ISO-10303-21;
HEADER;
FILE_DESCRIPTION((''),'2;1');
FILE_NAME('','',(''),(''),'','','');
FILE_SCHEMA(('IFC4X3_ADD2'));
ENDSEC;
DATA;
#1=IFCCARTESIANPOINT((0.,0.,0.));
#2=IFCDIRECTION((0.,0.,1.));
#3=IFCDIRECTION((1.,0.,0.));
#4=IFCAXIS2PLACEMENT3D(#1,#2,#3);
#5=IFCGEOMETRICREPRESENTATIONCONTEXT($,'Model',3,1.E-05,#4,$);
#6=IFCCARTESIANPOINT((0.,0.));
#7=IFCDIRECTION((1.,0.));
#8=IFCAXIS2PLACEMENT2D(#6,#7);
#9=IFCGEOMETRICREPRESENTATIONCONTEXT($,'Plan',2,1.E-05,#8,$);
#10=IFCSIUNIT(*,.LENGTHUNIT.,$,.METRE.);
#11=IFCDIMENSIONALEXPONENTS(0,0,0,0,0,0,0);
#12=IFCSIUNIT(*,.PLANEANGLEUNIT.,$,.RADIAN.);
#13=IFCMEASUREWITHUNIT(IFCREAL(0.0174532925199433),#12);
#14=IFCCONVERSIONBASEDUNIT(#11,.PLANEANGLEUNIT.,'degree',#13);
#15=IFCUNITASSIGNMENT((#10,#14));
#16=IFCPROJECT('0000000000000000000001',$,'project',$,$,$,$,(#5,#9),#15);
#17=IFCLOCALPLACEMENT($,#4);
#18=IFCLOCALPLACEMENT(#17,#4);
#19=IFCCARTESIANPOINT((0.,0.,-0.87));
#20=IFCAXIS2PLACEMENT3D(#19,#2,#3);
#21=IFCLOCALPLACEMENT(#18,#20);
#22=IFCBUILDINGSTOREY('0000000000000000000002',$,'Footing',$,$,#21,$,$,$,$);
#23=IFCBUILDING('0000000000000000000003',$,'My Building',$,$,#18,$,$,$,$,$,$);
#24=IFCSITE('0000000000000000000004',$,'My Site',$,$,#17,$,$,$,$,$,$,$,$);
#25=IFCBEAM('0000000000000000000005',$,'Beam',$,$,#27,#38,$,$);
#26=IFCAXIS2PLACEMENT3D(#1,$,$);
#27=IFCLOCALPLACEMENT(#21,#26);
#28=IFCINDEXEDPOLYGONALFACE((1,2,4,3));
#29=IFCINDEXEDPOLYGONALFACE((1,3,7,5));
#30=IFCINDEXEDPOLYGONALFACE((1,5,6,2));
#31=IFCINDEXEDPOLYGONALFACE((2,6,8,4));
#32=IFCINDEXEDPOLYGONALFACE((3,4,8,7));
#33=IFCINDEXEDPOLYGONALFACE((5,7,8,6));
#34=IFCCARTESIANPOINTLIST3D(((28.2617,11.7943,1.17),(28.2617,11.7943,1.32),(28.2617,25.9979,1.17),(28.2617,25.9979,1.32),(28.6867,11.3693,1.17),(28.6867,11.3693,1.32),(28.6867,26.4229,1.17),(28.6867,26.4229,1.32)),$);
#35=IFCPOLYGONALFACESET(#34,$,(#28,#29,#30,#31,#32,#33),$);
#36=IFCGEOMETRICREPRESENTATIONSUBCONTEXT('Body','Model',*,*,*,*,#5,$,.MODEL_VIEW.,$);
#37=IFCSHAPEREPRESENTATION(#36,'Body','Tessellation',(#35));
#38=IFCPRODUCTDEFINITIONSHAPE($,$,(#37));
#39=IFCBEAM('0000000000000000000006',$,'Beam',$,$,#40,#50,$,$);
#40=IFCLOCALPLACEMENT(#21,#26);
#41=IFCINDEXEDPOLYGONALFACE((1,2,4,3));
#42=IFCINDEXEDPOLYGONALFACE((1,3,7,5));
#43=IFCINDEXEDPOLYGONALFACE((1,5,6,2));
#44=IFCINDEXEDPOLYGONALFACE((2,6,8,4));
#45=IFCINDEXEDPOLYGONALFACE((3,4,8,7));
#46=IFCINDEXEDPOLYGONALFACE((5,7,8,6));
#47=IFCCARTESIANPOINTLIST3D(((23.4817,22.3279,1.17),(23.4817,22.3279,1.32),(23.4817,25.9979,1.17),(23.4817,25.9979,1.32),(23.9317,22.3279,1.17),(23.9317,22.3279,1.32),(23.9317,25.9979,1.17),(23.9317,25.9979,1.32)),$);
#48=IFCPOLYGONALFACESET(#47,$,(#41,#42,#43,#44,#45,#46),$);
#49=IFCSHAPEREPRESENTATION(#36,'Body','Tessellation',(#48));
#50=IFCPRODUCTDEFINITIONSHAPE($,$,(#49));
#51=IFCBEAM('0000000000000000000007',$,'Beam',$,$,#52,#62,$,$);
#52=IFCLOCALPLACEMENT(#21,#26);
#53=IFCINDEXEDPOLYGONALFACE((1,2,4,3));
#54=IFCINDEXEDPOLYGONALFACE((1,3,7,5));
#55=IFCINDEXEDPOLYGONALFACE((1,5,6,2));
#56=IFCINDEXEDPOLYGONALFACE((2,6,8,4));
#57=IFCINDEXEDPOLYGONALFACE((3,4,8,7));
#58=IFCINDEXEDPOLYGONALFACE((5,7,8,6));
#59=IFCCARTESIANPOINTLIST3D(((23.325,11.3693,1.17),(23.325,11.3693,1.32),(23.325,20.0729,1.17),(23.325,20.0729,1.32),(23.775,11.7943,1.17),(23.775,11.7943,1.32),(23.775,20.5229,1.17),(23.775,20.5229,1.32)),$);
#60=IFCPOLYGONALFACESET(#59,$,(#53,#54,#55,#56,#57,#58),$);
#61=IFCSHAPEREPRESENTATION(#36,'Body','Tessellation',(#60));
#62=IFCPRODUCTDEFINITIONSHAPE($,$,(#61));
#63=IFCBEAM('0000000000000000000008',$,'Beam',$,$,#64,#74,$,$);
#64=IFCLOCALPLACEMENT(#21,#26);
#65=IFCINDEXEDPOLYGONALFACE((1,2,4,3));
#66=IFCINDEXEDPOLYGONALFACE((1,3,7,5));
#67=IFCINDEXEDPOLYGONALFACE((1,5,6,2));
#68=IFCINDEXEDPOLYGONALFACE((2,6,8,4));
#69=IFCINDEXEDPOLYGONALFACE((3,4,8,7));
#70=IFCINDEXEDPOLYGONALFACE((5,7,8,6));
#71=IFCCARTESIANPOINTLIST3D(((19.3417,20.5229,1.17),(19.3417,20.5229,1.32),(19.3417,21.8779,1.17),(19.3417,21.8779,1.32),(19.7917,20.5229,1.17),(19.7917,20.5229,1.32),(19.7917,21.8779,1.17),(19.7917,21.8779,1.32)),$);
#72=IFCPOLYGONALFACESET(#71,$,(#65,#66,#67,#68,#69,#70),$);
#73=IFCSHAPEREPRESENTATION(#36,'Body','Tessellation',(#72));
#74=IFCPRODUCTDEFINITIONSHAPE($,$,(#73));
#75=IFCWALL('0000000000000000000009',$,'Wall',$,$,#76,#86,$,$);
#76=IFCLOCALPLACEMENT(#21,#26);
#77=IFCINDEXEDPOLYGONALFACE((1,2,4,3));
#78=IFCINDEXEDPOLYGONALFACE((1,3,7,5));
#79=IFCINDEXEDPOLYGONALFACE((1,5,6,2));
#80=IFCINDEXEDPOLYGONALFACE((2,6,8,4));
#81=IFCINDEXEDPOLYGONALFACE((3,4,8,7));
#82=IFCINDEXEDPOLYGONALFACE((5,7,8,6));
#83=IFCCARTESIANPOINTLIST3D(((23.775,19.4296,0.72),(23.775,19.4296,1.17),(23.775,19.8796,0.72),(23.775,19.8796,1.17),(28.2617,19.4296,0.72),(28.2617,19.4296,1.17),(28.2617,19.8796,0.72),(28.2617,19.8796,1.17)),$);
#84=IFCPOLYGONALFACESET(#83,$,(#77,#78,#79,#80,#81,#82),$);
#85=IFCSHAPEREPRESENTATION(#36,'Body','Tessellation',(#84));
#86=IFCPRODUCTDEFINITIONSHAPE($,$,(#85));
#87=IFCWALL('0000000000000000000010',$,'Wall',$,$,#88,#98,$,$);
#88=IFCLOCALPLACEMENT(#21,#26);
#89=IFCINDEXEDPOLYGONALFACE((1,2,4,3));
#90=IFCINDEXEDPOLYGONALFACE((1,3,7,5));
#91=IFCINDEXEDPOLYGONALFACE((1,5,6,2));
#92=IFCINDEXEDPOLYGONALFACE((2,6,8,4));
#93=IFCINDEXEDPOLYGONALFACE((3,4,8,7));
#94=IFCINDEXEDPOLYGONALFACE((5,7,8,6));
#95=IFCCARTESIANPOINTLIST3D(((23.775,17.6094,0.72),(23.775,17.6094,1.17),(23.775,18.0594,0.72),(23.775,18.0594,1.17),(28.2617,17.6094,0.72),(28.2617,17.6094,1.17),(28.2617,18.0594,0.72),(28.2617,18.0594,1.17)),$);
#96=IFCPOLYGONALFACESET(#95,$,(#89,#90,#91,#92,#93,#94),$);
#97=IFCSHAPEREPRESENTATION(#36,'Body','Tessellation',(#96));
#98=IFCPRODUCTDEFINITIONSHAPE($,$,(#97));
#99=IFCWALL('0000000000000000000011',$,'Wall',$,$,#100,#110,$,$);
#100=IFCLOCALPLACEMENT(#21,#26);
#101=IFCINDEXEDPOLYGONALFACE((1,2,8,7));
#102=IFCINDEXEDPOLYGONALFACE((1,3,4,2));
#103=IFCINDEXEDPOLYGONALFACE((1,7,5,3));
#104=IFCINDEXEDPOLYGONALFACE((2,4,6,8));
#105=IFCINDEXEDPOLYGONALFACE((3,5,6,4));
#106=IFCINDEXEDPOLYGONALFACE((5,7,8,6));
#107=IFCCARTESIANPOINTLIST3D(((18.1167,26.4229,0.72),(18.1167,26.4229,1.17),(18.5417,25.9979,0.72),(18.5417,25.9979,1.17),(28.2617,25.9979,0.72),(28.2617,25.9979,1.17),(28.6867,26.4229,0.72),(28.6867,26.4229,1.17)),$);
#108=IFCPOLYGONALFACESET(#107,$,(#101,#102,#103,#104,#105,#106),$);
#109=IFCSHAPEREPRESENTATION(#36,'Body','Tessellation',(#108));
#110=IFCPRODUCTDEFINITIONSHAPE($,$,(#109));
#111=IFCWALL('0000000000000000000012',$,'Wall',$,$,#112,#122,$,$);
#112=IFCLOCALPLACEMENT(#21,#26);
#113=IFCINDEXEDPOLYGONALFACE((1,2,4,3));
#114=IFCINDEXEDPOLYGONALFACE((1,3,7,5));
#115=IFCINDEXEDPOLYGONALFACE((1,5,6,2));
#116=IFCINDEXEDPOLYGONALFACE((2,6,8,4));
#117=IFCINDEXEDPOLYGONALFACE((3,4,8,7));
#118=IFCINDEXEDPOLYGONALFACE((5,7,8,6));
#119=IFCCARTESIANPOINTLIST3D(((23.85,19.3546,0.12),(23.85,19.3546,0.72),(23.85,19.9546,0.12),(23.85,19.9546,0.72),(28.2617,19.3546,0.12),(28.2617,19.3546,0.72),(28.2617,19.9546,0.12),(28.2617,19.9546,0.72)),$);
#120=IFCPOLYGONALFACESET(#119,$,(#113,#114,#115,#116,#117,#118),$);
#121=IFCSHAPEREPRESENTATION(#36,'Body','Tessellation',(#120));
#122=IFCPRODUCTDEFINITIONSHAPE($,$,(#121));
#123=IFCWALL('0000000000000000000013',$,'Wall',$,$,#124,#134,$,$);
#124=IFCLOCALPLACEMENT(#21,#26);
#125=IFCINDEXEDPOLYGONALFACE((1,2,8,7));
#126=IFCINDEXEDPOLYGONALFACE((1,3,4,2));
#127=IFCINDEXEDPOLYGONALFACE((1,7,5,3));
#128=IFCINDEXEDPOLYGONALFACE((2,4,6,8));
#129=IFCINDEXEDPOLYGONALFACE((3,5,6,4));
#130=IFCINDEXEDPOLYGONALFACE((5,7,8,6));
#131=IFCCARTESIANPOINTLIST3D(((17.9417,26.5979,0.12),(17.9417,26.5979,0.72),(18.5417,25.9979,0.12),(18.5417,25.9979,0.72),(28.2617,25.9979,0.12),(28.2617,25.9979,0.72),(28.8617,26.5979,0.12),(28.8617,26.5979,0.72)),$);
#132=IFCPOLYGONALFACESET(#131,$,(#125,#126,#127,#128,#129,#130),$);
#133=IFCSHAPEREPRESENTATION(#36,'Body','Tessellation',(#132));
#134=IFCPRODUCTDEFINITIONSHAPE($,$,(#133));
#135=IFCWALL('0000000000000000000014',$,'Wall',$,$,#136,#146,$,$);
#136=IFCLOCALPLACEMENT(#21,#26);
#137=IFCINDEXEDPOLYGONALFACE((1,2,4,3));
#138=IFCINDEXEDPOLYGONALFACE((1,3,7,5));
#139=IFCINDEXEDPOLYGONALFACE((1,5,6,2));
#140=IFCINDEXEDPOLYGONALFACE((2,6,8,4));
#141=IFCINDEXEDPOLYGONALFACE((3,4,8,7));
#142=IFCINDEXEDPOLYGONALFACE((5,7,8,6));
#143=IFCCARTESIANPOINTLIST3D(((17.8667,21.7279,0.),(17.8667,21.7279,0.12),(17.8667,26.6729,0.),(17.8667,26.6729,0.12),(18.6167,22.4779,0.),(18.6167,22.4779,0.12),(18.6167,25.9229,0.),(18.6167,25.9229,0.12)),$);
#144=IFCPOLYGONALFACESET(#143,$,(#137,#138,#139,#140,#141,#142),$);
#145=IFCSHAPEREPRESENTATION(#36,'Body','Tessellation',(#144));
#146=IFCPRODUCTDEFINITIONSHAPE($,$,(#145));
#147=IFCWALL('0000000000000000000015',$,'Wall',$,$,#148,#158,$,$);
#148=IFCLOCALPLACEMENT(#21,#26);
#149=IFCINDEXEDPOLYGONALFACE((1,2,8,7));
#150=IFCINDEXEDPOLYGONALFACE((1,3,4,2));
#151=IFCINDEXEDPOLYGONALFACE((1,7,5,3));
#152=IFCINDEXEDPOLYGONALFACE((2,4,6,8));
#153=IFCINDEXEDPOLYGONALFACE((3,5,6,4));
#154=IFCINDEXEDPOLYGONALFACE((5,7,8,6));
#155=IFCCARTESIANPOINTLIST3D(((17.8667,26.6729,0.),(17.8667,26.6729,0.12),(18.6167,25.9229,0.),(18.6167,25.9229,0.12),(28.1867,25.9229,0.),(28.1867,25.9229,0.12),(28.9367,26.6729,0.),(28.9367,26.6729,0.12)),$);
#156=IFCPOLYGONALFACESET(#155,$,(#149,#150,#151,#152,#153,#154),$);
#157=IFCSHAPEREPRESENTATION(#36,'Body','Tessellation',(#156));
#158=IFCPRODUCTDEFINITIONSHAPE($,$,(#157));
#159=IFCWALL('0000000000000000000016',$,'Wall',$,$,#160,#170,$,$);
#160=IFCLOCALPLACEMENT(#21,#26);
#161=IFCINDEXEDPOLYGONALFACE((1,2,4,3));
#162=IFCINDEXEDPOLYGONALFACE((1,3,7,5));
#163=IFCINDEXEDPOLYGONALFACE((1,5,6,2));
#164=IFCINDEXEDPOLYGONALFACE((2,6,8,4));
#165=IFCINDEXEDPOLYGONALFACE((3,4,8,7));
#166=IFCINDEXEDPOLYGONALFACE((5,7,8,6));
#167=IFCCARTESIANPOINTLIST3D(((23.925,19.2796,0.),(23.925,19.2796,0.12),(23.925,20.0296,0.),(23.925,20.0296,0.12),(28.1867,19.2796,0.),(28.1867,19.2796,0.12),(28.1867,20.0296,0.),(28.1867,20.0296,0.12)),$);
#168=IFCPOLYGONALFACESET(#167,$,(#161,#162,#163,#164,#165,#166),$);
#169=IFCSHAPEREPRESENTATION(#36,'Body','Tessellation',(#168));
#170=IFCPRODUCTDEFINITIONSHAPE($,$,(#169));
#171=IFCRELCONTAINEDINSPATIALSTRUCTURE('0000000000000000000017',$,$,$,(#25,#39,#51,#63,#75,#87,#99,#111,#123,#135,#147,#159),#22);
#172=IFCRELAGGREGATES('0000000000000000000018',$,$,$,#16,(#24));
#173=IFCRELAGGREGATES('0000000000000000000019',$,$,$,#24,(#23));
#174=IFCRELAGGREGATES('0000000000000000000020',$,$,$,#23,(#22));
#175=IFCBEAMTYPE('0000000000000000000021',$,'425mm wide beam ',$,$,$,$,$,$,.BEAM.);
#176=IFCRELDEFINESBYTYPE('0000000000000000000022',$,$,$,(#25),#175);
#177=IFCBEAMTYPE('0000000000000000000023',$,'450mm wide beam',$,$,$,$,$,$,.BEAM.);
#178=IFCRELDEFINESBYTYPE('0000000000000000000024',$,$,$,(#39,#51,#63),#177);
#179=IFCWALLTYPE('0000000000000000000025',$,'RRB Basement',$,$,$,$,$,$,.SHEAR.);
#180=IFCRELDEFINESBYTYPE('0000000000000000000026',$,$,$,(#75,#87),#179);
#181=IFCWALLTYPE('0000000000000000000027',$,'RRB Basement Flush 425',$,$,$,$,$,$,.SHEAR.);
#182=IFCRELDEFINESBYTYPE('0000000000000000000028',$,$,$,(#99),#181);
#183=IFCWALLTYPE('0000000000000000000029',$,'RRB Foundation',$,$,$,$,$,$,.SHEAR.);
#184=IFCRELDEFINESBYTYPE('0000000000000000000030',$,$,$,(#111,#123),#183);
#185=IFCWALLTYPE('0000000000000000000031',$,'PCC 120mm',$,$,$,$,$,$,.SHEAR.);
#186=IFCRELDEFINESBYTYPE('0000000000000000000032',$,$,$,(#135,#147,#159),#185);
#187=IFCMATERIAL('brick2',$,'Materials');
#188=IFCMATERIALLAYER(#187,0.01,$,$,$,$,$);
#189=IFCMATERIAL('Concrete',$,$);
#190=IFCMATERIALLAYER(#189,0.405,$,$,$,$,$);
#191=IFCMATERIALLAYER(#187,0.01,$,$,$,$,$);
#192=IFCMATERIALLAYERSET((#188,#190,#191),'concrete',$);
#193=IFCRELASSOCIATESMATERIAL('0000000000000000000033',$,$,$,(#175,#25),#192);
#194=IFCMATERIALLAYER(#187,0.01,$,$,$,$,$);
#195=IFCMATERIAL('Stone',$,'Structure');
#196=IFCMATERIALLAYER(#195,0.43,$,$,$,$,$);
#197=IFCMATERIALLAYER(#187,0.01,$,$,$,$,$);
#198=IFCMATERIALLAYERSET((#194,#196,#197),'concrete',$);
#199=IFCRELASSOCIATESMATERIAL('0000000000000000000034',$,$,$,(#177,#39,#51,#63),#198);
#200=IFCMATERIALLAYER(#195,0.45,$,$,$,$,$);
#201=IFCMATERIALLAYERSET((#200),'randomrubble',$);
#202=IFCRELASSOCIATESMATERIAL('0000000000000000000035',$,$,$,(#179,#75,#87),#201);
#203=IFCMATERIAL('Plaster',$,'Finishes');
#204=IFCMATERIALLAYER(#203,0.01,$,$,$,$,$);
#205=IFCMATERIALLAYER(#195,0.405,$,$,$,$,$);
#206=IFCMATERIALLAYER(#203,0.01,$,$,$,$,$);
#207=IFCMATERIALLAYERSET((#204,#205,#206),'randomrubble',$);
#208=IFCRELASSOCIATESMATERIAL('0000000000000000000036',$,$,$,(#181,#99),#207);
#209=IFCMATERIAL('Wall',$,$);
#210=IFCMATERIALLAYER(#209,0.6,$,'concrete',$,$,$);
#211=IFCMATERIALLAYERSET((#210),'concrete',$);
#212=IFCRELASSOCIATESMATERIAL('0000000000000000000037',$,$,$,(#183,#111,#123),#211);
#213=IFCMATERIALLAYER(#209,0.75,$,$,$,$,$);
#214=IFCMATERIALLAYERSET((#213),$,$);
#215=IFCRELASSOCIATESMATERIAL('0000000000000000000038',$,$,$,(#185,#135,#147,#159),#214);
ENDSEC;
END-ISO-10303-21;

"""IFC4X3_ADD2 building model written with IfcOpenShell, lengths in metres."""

from ifc_helpers import new_model, entity, si_unit, converted_unit, frame, origin_with_axes, origin_2d_with_axis, place, context, subcontext, project, spatial, line, indexed_curve, outline, extrude, material, layer, layer_set, layer_usage, type_object, element, save


model = new_model("IFC4X3_ADD2")

# Units and contexts
model_context = context("Model", 3, precision=1e-05, world=origin_with_axes())
plan_context = context("Plan", 2, precision=1e-05, world=origin_2d_with_axis())
body_context = subcontext(model_context, "Body", "Model", "MODEL_VIEW")
ifc_project = project(units=[si_unit("LENGTHUNIT", "METRE"), converted_unit("PLANEANGLEUNIT", "degree", entity("IfcReal", 0.0174532925199433), si_unit("PLANEANGLEUNIT", "RADIAN"), dimensions=[0, 0, 0, 0, 0, 0, 0])], contexts=[model_context, plan_context])

# Site, building, storey
site_placement = place(None, origin_with_axes())
site = spatial("IfcSite", under=ifc_project, at=site_placement, Name="My Site")
building_placement = place(site_placement, origin_with_axes())
building = spatial("IfcBuilding", under=site, at=building_placement, Name="My Building")
storey_placement = place(building_placement, frame((0.0, 0.0, -0.87), z_axis=(0.0, 0.0, 1.0), x_axis=(1.0, 0.0, 0.0)))
storey = spatial("IfcBuildingStorey", under=building, at=storey_placement, Name="Footing")

# Beams
ifc_material_1 = material(Name="brick2", Category="Materials")
ifc_layer_1 = layer(ifc_material_1, 0.01)
ifc_material_2 = material(Name="Concrete")
ifc_layer_2 = layer(ifc_material_2, 0.405)
ifc_layer_3 = layer(ifc_material_1, 0.01)
ifc_layer_set_1 = layer_set([ifc_layer_1, ifc_layer_2, ifc_layer_3], Name="concrete")
ifc_layer_usage_1 = layer_usage(ifc_layer_set_1, "AXIS2", "POSITIVE", 0.0)
beam_type_1 = type_object("IfcBeamType", Name="425mm wide beam ", PredefinedType="BEAM", material=ifc_layer_set_1)
beam_1_placement = place(storey_placement, frame((28.2617, 25.9979, 1.17), z_axis=(0.0, 0.0, 1.0), x_axis=(0.0, -1.0, 0.0)))
element("IfcBeam", 1, at=beam_1_placement, inside=storey, type_object=beam_type_1, material=ifc_layer_usage_1, Name="Beam", context=body_context, shape_type="SweptSolid", body=[
    extrude(outline(indexed_curve([(0.0, 0.0), (-0.425, 0.425), (14.6286, 0.425), (14.2036, 0.0)], segments=[line(1, 2, 3, 4, 1)])), origin_with_axes(), (0.0, 0.0, 1.0), 0.15),
])
ifc_layer_4 = layer(ifc_material_1, 0.01)
ifc_material_3 = material(Name="Stone", Category="Structure")
ifc_layer_5 = layer(ifc_material_3, 0.43)
ifc_layer_6 = layer(ifc_material_1, 0.01)
ifc_layer_set_2 = layer_set([ifc_layer_4, ifc_layer_5, ifc_layer_6], Name="concrete")
ifc_layer_usage_2 = layer_usage(ifc_layer_set_2, "AXIS2", "POSITIVE", 0.0)
beam_type_2 = type_object("IfcBeamType", Name="450mm wide beam", PredefinedType="BEAM", material=ifc_layer_set_2)
beam_2_placement = place(storey_placement, frame((23.4817, 25.9979, 1.17), z_axis=(0.0, 0.0, 1.0), x_axis=(0.0, -1.0, 0.0)))
element("IfcBeam", 2, at=beam_2_placement, inside=storey, type_object=beam_type_2, material=ifc_layer_usage_2, Name="Beam", context=body_context, shape_type="SweptSolid", body=[
    extrude(outline(indexed_curve([(0.0, 0.0), (0.0, 0.45), (3.67, 0.45), (3.67, 0.0)], segments=[line(1, 2, 3, 4, 1)])), origin_with_axes(), (0.0, 0.0, 1.0), 0.15),
])
ifc_layer_usage_3 = layer_usage(ifc_layer_set_2, "AXIS2", "POSITIVE", 0.0)
beam_3_placement = place(storey_placement, frame((23.325, 20.0729, 1.17), z_axis=(0.0, 0.0, 1.0), x_axis=(0.0, -1.0, 0.0)))
element("IfcBeam", 3, at=beam_3_placement, inside=storey, type_object=beam_type_2, material=ifc_layer_usage_3, Name="Beam", context=body_context, shape_type="SweptSolid", body=[
    extrude(outline(indexed_curve([(0.0, 0.0), (-0.45, 0.45), (8.2786, 0.45), (8.7036, 0.0)], segments=[line(1, 2, 3, 4, 1)])), origin_with_axes(), (0.0, 0.0, 1.0), 0.15),
])
ifc_layer_usage_4 = layer_usage(ifc_layer_set_2, "AXIS2", "POSITIVE", 0.0)
beam_4_placement = place(storey_placement, frame((19.3417, 21.8779, 1.17), z_axis=(0.0, 0.0, 1.0), x_axis=(0.0, -1.0, 0.0)))
element("IfcBeam", 4, at=beam_4_placement, inside=storey, type_object=beam_type_2, material=ifc_layer_usage_4, Name="Beam", context=body_context, shape_type="SweptSolid", body=[
    extrude(outline(indexed_curve([(0.0, 0.0), (0.0, 0.45), (1.355, 0.45), (1.355, 0.0)], segments=[line(1, 2, 3, 4, 1)])), origin_with_axes(), (0.0, 0.0, 1.0), 0.15),
])

# Walls
ifc_layer_7 = layer(ifc_material_3, 0.45)
ifc_layer_set_3 = layer_set([ifc_layer_7], Name="randomrubble")
wall_type_1 = type_object("IfcWallType", Name="RRB Basement", PredefinedType="SHEAR", material=ifc_layer_set_3)
ifc_layer_usage_5 = layer_usage(ifc_layer_set_3, "AXIS2", "POSITIVE", 0.0)
wall_1_placement = place(storey_placement, frame((23.775, 19.4296, 0.72), z_axis=(0.0, 0.0, 1.0), x_axis=(1.0, -0.000001, 0.0)))
element("IfcWall", 5, at=wall_1_placement, inside=storey, type_object=wall_type_1, material=ifc_layer_usage_5, Name="Wall", context=body_context, shape_type="SweptSolid", body=[
    extrude(outline(indexed_curve([(0.0, 0.0), (0.0, 0.45), (4.4867, 0.45), (4.4867, 0.0)], segments=[line(1, 2, 3, 4, 1)])), origin_with_axes(), (0.0, 0.0, 1.0), 0.45),
])
ifc_layer_usage_6 = layer_usage(ifc_layer_set_3, "AXIS2", "POSITIVE", 0.0)
wall_2_placement = place(storey_placement, frame((23.775, 17.6094, 0.72), z_axis=(0.0, 0.0, 1.0), x_axis=(1.0, -0.000001, 0.0)))
element("IfcWall", 6, at=wall_2_placement, inside=storey, type_object=wall_type_1, material=ifc_layer_usage_6, Name="Wall", context=body_context, shape_type="SweptSolid", body=[
    extrude(outline(indexed_curve([(0.0, 0.0), (0.0, 0.45), (4.4867, 0.45), (4.4867, 0.0)], segments=[line(1, 2, 3, 4, 1)])), origin_with_axes(), (0.0, 0.0, 1.0), 0.45),
])
ifc_material_4 = material(Name="Plaster", Category="Finishes")
ifc_layer_8 = layer(ifc_material_4, 0.01)
ifc_layer_9 = layer(ifc_material_3, 0.405)
ifc_layer_10 = layer(ifc_material_4, 0.01)
ifc_layer_set_4 = layer_set([ifc_layer_8, ifc_layer_9, ifc_layer_10], Name="randomrubble")
ifc_layer_usage_7 = layer_usage(ifc_layer_set_4, "AXIS2", "POSITIVE", 0.0)
wall_type_2 = type_object("IfcWallType", Name="RRB Basement Flush 425", PredefinedType="SHEAR", material=ifc_layer_set_4)
wall_3_placement = place(storey_placement, frame((28.6867, 26.4229, 0.72), z_axis=(0.0, 0.0, 1.0), x_axis=(-1.0, 0.0, 0.0)))
element("IfcWall", 7, at=wall_3_placement, inside=storey, type_object=wall_type_2, material=ifc_layer_usage_7, Name="Wall", context=body_context, shape_type="SweptSolid", body=[
    extrude(outline(indexed_curve([(0.0, 0.0), (0.425, 0.425), (10.145, 0.425), (10.57, 0.0)], segments=[line(1, 2, 3, 4, 1)])), origin_with_axes(), (0.0, 0.0, 1.0), 0.45),
])
ifc_material_5 = material(Name="Wall")
ifc_layer_11 = layer(ifc_material_5, 0.6, Name="concrete")
ifc_layer_set_5 = layer_set([ifc_layer_11], Name="concrete")
wall_type_3 = type_object("IfcWallType", Name="RRB Foundation", PredefinedType="SHEAR", material=ifc_layer_set_5)
ifc_layer_usage_8 = layer_usage(ifc_layer_set_5, "AXIS2", "POSITIVE", 0.0)
wall_4_placement = place(storey_placement, frame((23.85, 19.3546, 0.12), z_axis=(0.0, 0.0, 1.0), x_axis=(1.0, -0.000001, 0.0)))
element("IfcWall", 8, at=wall_4_placement, inside=storey, type_object=wall_type_3, material=ifc_layer_usage_8, Name="Wall", context=body_context, shape_type="SweptSolid", body=[
    extrude(outline(indexed_curve([(0.0, 0.0), (0.0, 0.6), (4.4117, 0.6), (4.4117, 0.0)], segments=[line(1, 2, 3, 4, 1)])), origin_with_axes(), (0.0, 0.0, 1.0), 0.6),
])
ifc_layer_usage_9 = layer_usage(ifc_layer_set_5, "AXIS2", "POSITIVE", 0.0)
wall_5_placement = place(storey_placement, frame((28.8617, 26.5979, 0.12), z_axis=(0.0, 0.0, 1.0), x_axis=(-1.0, 0.0, 0.0)))
element("IfcWall", 9, at=wall_5_placement, inside=storey, type_object=wall_type_3, material=ifc_layer_usage_9, Name="Wall", context=body_context, shape_type="SweptSolid", body=[
    extrude(outline(indexed_curve([(0.0, 0.0), (0.6, 0.6), (10.32, 0.6), (10.92, 0.0)], segments=[line(1, 2, 3, 4, 1)])), origin_with_axes(), (0.0, 0.0, 1.0), 0.6),
])
ifc_layer_12 = layer(ifc_material_5, 0.75)
ifc_layer_set_6 = layer_set([ifc_layer_12])
wall_type_4 = type_object("IfcWallType", Name="PCC 120mm", PredefinedType="SHEAR", material=ifc_layer_set_6)
ifc_layer_usage_10 = layer_usage(ifc_layer_set_6, "AXIS2", "POSITIVE", 0.0)
wall_6_placement = place(storey_placement, frame((18.6167, 21.7279, 0.0), z_axis=(0.0, 0.0, 1.0), x_axis=(0.0, 1.0, 0.0)))
element("IfcWall", 10, at=wall_6_placement, inside=storey, type_object=wall_type_4, material=ifc_layer_usage_10, Name="Wall", context=body_context, shape_type="SweptSolid", body=[
    extrude(outline(indexed_curve([(0.75, 0.0), (0.0, 0.75), (4.945, 0.75), (4.195, 0.0)], segments=[line(1, 2, 3, 4, 1)])), origin_with_axes(), (0.0, 0.0, 1.0), 0.12),
])
ifc_layer_usage_11 = layer_usage(ifc_layer_set_6, "AXIS2", "POSITIVE", 0.0)
wall_7_placement = place(storey_placement, frame((28.9367, 26.6729, 0.0), z_axis=(0.0, 0.0, 1.0), x_axis=(-1.0, 0.0, 0.0)))
element("IfcWall", 11, at=wall_7_placement, inside=storey, type_object=wall_type_4, material=ifc_layer_usage_11, Name="Wall", context=body_context, shape_type="SweptSolid", body=[
    extrude(outline(indexed_curve([(0.0, 0.0), (0.75, 0.75), (10.32, 0.75), (11.07, 0.0)], segments=[line(1, 2, 3, 4, 1)])), origin_with_axes(), (0.0, 0.0, 1.0), 0.12),
])
ifc_layer_usage_12 = layer_usage(ifc_layer_set_6, "AXIS2", "POSITIVE", 0.0)
wall_8_placement = place(storey_placement, frame((23.925, 19.2796, 0.0), z_axis=(0.0, 0.0, 1.0), x_axis=(1.0, -0.000001, 0.0)))
element("IfcWall", 12, at=wall_8_placement, inside=storey, type_object=wall_type_4, material=ifc_layer_usage_12, Name="Wall", context=body_context, shape_type="SweptSolid", body=[
    extrude(outline(indexed_curve([(0.0, 0.0), (0.0, 0.75), (4.2617, 0.75), (4.2617, 0.0)], segments=[line(1, 2, 3, 4, 1)])), origin_with_axes(), (0.0, 0.0, 1.0), 0.12),
])

save(model, "model.ifc")
